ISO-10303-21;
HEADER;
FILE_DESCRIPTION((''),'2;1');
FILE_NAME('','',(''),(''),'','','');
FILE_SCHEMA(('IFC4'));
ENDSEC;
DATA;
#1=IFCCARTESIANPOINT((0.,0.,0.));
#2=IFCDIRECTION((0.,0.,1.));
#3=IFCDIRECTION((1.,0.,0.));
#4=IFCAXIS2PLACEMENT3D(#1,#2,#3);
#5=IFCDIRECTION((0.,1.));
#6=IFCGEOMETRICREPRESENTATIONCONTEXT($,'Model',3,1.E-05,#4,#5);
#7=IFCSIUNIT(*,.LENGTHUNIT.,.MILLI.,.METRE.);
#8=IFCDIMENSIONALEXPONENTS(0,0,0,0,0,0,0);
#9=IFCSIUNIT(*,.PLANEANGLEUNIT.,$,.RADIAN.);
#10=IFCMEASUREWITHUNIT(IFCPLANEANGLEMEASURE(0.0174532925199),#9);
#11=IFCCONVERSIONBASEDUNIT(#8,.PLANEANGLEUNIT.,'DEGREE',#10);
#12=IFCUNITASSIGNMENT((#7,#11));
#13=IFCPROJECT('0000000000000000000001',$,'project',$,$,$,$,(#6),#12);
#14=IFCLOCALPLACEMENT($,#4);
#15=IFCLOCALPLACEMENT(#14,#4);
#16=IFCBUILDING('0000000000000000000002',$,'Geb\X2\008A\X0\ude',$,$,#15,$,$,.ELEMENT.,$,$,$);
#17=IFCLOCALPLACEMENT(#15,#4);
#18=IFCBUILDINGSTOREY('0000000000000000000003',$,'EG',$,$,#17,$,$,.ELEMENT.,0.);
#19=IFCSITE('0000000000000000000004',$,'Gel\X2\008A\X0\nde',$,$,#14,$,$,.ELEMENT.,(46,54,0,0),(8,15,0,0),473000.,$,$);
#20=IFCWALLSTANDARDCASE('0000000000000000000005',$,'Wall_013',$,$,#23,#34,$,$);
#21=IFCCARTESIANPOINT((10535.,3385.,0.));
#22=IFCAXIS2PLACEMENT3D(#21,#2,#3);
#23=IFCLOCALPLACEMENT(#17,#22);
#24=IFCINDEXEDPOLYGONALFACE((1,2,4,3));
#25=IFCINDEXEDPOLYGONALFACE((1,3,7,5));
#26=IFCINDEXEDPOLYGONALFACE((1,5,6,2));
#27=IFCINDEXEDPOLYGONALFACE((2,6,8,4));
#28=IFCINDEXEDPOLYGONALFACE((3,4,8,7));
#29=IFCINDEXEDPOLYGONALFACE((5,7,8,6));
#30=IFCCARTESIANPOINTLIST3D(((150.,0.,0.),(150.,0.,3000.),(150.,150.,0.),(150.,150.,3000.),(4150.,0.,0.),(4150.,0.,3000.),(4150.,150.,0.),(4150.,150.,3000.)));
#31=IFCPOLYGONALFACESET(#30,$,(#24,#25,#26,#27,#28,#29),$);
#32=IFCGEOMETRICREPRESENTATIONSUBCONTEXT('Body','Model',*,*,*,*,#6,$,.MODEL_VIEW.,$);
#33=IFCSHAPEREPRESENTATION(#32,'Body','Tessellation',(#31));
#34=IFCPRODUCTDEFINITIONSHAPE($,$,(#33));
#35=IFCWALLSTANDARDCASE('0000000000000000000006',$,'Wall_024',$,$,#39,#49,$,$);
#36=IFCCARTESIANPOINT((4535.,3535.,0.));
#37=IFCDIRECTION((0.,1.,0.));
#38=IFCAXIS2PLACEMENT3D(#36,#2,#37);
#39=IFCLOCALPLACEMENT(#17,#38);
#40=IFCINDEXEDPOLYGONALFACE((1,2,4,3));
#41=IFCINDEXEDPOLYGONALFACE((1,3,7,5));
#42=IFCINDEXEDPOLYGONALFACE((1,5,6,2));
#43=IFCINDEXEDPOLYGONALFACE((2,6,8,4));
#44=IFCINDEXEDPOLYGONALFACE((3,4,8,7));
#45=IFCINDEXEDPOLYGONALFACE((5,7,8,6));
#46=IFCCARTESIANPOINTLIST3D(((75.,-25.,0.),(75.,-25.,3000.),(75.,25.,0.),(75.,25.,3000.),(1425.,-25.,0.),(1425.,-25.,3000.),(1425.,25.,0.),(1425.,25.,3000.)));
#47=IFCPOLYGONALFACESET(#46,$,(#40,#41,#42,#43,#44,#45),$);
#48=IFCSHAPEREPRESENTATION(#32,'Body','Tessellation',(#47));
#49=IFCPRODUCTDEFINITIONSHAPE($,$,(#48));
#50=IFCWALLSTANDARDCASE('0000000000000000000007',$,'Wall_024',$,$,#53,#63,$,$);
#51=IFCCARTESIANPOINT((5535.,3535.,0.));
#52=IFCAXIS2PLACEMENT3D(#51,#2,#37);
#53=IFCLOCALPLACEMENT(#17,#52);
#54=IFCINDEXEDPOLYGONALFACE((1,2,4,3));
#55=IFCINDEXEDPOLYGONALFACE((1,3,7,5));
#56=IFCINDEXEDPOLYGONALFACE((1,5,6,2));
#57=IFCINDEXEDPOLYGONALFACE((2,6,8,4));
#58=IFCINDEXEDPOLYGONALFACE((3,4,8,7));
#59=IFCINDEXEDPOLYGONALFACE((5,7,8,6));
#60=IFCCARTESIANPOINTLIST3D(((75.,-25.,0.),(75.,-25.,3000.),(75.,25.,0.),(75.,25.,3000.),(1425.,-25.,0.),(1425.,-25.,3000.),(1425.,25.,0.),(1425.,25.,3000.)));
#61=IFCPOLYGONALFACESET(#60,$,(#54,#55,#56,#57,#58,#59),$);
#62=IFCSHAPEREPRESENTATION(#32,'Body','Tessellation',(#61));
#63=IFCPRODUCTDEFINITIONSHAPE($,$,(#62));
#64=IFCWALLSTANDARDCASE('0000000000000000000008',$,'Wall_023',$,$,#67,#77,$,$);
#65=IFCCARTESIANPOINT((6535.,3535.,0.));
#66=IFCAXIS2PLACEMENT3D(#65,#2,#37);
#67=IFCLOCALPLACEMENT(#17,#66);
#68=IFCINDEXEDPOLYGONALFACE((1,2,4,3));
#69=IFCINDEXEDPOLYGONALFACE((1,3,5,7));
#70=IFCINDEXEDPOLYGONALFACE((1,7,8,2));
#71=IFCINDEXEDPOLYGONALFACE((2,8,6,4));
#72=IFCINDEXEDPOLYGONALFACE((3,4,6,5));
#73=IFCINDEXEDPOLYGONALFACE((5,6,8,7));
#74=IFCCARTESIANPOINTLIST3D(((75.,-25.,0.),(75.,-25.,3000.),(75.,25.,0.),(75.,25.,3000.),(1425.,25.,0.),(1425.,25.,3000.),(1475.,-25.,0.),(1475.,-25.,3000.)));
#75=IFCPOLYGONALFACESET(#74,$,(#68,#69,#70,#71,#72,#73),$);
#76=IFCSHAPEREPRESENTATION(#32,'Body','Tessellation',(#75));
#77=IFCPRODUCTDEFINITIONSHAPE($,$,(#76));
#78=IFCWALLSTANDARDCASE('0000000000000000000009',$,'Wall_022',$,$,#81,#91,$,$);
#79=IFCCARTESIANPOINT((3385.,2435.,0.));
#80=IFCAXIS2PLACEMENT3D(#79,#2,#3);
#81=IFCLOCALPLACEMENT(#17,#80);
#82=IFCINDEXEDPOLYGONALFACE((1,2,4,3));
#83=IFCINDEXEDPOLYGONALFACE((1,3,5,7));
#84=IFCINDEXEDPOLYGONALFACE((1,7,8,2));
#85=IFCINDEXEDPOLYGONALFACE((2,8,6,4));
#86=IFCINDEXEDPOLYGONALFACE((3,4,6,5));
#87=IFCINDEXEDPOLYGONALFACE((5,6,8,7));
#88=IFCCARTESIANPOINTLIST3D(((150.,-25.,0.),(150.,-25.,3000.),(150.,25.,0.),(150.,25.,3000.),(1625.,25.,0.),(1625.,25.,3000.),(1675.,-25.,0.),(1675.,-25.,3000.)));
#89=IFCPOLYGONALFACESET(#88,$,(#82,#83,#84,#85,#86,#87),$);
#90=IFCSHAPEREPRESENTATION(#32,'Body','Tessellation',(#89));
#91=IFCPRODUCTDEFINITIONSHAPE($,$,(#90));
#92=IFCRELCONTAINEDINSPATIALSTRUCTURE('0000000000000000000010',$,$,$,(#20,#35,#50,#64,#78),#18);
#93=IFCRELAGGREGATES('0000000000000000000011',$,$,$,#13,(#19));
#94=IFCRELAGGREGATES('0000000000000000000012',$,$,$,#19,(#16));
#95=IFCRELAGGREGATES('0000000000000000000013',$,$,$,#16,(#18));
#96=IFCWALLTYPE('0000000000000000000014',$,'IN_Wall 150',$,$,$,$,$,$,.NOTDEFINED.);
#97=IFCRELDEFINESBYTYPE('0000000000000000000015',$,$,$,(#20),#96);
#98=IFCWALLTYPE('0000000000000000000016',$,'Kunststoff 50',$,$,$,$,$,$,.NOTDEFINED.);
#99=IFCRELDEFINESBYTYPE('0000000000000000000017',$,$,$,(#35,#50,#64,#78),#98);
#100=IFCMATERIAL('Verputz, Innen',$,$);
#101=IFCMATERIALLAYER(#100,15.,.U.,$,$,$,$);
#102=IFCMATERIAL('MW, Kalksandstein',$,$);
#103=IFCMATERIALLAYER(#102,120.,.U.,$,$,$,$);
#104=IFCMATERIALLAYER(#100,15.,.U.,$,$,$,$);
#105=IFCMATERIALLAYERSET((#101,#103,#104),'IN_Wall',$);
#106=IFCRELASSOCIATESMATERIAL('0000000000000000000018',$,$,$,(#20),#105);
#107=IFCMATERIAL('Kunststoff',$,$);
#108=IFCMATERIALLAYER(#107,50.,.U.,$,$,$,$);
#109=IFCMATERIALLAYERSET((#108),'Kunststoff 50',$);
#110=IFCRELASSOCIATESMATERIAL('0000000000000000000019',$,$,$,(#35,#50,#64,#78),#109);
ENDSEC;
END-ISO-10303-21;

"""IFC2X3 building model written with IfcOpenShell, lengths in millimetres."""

from ifc_helpers import new_model, entity, si_unit, converted_unit, direction, frame, origin_with_axes, place, context, subcontext, project, spatial, polyline, outline, extrude, material, layer, layer_set, layer_usage, type_object, element, save


model = new_model("IFC2X3")

# Units and contexts
model_context = context("Model", 3, precision=1e-05, world=origin_with_axes(), true_north=direction((0.0, 1.0)))
body_context = subcontext(model_context, "Body", "Model", "MODEL_VIEW")
ifc_project = project(units=[si_unit("LENGTHUNIT", "METRE", prefix="MILLI"), converted_unit("PLANEANGLEUNIT", "DEGREE", entity("IfcPlaneAngleMeasure", 0.0174532925199), si_unit("PLANEANGLEUNIT", "RADIAN"), dimensions=[0, 0, 0, 0, 0, 0, 0])], contexts=[model_context])

# Site, building, storey
site_placement = place(None, origin_with_axes())
site = spatial("IfcSite", under=ifc_project, at=site_placement, Name="Gel\u008ande", CompositionType="ELEMENT", RefLatitude=(46, 54, 0, 0), RefLongitude=(8, 15, 0, 0), RefElevation=473000.0)
building_placement = place(site_placement, origin_with_axes())
building = spatial("IfcBuilding", under=site, at=building_placement, Name="Geb\u008aude", CompositionType="ELEMENT")
storey_placement = place(building_placement, origin_with_axes())
storey = spatial("IfcBuildingStorey", under=building, at=storey_placement, Name="EG", CompositionType="ELEMENT", Elevation=0.0)

# Shared definitions
ifc_material_1 = material(Name="Verputz, Innen")

# Walls
ifc_layer_1 = layer(ifc_material_1, 15.0, ventilated="UNKNOWN")
ifc_material_2 = material(Name="MW, Kalksandstein")
ifc_layer_2 = layer(ifc_material_2, 120.0, ventilated="UNKNOWN")
ifc_layer_3 = layer(ifc_material_1, 15.0, ventilated="UNKNOWN")
ifc_layer_set_1 = layer_set([ifc_layer_1, ifc_layer_2, ifc_layer_3], Name="IN_Wall")
ifc_layer_usage_1 = layer_usage(ifc_layer_set_1, "AXIS2", "POSITIVE", 0.0)
wall_type_1 = type_object("IfcWallType", Name="IN_Wall 150", PredefinedType="NOTDEFINED")
wall_1_placement = place(storey_placement, frame((10535.0, 3385.0, 0.0), z_axis=(0.0, 0.0, 1.0), x_axis=(1.0, 0.0, 0.0)))
element("IfcWallStandardCase", 1, at=wall_1_placement, inside=storey, type_object=wall_type_1, material=ifc_layer_usage_1, Name="Wall_013", context=body_context, shape_type="SweptSolid", body=[
    extrude(outline(polyline([(150.0, 0.0), (4150.0, 0.0), (4150.0, 150.0), (150.0, 150.0), (150.0, 0.0)])), origin_with_axes(), (0.0, 0.0, 1.0), 3000.0),
])
ifc_material_3 = material(Name="Kunststoff")
ifc_layer_4 = layer(ifc_material_3, 50.0, ventilated="UNKNOWN")
ifc_layer_set_2 = layer_set([ifc_layer_4], Name="Kunststoff 50")
ifc_layer_usage_2 = layer_usage(ifc_layer_set_2, "AXIS2", "POSITIVE", -25.0)
wall_type_2 = type_object("IfcWallType", Name="Kunststoff 50", PredefinedType="NOTDEFINED")
wall_2_placement = place(storey_placement, frame((4535.0, 3535.0, 0.0), z_axis=(0.0, 0.0, 1.0), x_axis=(0.0, 1.0, 0.0)))
element("IfcWallStandardCase", 2, at=wall_2_placement, inside=storey, type_object=wall_type_2, material=ifc_layer_usage_2, Name="Wall_024", context=body_context, shape_type="SweptSolid", body=[
    extrude(outline(polyline([(75.0, -25.0), (1425.0, -25.0), (1425.0, 25.0), (75.0, 25.0), (75.0, -25.0)])), origin_with_axes(), (0.0, 0.0, 1.0), 3000.0),
])
ifc_layer_usage_3 = layer_usage(ifc_layer_set_2, "AXIS2", "POSITIVE", -25.0)
wall_3_placement = place(storey_placement, frame((5535.0, 3535.0, 0.0), z_axis=(0.0, 0.0, 1.0), x_axis=(0.0, 1.0, 0.0)))
element("IfcWallStandardCase", 3, at=wall_3_placement, inside=storey, type_object=wall_type_2, material=ifc_layer_usage_3, Name="Wall_024", context=body_context, shape_type="SweptSolid", body=[
    extrude(outline(polyline([(75.0, -25.0), (1425.0, -25.0), (1425.0, 25.0), (75.0, 25.0), (75.0, -25.0)])), origin_with_axes(), (0.0, 0.0, 1.0), 3000.0),
])
ifc_layer_usage_4 = layer_usage(ifc_layer_set_2, "AXIS2", "POSITIVE", -25.0)
wall_4_placement = place(storey_placement, frame((6535.0, 3535.0, 0.0), z_axis=(0.0, 0.0, 1.0), x_axis=(0.0, 1.0, 0.0)))
element("IfcWallStandardCase", 4, at=wall_4_placement, inside=storey, type_object=wall_type_2, material=ifc_layer_usage_4, Name="Wall_023", context=body_context, shape_type="SweptSolid", body=[
    extrude(outline(polyline([(75.0, -25.0), (1475.0, -25.0), (1425.0, 25.0), (75.0, 25.0), (75.0, -25.0)])), origin_with_axes(), (0.0, 0.0, 1.0), 3000.0),
])

# Wall
ifc_layer_usage_5 = layer_usage(ifc_layer_set_2, "AXIS2", "NEGATIVE", 25.0)
wall_5_placement = place(storey_placement, frame((3385.0, 2435.0, 0.0), z_axis=(0.0, 0.0, 1.0), x_axis=(1.0, 0.0, 0.0)))
element("IfcWallStandardCase", 5, at=wall_5_placement, inside=storey, type_object=wall_type_2, material=ifc_layer_usage_5, Name="Wall_022", context=body_context, shape_type="SweptSolid", body=[
    extrude(outline(polyline([(150.0, -25.0), (1675.0, -25.0), (1625.0, 25.0), (150.0, 25.0), (150.0, -25.0)])), origin_with_axes(), (0.0, 0.0, 1.0), 3000.0),
])

save(model, "model.ifc")
